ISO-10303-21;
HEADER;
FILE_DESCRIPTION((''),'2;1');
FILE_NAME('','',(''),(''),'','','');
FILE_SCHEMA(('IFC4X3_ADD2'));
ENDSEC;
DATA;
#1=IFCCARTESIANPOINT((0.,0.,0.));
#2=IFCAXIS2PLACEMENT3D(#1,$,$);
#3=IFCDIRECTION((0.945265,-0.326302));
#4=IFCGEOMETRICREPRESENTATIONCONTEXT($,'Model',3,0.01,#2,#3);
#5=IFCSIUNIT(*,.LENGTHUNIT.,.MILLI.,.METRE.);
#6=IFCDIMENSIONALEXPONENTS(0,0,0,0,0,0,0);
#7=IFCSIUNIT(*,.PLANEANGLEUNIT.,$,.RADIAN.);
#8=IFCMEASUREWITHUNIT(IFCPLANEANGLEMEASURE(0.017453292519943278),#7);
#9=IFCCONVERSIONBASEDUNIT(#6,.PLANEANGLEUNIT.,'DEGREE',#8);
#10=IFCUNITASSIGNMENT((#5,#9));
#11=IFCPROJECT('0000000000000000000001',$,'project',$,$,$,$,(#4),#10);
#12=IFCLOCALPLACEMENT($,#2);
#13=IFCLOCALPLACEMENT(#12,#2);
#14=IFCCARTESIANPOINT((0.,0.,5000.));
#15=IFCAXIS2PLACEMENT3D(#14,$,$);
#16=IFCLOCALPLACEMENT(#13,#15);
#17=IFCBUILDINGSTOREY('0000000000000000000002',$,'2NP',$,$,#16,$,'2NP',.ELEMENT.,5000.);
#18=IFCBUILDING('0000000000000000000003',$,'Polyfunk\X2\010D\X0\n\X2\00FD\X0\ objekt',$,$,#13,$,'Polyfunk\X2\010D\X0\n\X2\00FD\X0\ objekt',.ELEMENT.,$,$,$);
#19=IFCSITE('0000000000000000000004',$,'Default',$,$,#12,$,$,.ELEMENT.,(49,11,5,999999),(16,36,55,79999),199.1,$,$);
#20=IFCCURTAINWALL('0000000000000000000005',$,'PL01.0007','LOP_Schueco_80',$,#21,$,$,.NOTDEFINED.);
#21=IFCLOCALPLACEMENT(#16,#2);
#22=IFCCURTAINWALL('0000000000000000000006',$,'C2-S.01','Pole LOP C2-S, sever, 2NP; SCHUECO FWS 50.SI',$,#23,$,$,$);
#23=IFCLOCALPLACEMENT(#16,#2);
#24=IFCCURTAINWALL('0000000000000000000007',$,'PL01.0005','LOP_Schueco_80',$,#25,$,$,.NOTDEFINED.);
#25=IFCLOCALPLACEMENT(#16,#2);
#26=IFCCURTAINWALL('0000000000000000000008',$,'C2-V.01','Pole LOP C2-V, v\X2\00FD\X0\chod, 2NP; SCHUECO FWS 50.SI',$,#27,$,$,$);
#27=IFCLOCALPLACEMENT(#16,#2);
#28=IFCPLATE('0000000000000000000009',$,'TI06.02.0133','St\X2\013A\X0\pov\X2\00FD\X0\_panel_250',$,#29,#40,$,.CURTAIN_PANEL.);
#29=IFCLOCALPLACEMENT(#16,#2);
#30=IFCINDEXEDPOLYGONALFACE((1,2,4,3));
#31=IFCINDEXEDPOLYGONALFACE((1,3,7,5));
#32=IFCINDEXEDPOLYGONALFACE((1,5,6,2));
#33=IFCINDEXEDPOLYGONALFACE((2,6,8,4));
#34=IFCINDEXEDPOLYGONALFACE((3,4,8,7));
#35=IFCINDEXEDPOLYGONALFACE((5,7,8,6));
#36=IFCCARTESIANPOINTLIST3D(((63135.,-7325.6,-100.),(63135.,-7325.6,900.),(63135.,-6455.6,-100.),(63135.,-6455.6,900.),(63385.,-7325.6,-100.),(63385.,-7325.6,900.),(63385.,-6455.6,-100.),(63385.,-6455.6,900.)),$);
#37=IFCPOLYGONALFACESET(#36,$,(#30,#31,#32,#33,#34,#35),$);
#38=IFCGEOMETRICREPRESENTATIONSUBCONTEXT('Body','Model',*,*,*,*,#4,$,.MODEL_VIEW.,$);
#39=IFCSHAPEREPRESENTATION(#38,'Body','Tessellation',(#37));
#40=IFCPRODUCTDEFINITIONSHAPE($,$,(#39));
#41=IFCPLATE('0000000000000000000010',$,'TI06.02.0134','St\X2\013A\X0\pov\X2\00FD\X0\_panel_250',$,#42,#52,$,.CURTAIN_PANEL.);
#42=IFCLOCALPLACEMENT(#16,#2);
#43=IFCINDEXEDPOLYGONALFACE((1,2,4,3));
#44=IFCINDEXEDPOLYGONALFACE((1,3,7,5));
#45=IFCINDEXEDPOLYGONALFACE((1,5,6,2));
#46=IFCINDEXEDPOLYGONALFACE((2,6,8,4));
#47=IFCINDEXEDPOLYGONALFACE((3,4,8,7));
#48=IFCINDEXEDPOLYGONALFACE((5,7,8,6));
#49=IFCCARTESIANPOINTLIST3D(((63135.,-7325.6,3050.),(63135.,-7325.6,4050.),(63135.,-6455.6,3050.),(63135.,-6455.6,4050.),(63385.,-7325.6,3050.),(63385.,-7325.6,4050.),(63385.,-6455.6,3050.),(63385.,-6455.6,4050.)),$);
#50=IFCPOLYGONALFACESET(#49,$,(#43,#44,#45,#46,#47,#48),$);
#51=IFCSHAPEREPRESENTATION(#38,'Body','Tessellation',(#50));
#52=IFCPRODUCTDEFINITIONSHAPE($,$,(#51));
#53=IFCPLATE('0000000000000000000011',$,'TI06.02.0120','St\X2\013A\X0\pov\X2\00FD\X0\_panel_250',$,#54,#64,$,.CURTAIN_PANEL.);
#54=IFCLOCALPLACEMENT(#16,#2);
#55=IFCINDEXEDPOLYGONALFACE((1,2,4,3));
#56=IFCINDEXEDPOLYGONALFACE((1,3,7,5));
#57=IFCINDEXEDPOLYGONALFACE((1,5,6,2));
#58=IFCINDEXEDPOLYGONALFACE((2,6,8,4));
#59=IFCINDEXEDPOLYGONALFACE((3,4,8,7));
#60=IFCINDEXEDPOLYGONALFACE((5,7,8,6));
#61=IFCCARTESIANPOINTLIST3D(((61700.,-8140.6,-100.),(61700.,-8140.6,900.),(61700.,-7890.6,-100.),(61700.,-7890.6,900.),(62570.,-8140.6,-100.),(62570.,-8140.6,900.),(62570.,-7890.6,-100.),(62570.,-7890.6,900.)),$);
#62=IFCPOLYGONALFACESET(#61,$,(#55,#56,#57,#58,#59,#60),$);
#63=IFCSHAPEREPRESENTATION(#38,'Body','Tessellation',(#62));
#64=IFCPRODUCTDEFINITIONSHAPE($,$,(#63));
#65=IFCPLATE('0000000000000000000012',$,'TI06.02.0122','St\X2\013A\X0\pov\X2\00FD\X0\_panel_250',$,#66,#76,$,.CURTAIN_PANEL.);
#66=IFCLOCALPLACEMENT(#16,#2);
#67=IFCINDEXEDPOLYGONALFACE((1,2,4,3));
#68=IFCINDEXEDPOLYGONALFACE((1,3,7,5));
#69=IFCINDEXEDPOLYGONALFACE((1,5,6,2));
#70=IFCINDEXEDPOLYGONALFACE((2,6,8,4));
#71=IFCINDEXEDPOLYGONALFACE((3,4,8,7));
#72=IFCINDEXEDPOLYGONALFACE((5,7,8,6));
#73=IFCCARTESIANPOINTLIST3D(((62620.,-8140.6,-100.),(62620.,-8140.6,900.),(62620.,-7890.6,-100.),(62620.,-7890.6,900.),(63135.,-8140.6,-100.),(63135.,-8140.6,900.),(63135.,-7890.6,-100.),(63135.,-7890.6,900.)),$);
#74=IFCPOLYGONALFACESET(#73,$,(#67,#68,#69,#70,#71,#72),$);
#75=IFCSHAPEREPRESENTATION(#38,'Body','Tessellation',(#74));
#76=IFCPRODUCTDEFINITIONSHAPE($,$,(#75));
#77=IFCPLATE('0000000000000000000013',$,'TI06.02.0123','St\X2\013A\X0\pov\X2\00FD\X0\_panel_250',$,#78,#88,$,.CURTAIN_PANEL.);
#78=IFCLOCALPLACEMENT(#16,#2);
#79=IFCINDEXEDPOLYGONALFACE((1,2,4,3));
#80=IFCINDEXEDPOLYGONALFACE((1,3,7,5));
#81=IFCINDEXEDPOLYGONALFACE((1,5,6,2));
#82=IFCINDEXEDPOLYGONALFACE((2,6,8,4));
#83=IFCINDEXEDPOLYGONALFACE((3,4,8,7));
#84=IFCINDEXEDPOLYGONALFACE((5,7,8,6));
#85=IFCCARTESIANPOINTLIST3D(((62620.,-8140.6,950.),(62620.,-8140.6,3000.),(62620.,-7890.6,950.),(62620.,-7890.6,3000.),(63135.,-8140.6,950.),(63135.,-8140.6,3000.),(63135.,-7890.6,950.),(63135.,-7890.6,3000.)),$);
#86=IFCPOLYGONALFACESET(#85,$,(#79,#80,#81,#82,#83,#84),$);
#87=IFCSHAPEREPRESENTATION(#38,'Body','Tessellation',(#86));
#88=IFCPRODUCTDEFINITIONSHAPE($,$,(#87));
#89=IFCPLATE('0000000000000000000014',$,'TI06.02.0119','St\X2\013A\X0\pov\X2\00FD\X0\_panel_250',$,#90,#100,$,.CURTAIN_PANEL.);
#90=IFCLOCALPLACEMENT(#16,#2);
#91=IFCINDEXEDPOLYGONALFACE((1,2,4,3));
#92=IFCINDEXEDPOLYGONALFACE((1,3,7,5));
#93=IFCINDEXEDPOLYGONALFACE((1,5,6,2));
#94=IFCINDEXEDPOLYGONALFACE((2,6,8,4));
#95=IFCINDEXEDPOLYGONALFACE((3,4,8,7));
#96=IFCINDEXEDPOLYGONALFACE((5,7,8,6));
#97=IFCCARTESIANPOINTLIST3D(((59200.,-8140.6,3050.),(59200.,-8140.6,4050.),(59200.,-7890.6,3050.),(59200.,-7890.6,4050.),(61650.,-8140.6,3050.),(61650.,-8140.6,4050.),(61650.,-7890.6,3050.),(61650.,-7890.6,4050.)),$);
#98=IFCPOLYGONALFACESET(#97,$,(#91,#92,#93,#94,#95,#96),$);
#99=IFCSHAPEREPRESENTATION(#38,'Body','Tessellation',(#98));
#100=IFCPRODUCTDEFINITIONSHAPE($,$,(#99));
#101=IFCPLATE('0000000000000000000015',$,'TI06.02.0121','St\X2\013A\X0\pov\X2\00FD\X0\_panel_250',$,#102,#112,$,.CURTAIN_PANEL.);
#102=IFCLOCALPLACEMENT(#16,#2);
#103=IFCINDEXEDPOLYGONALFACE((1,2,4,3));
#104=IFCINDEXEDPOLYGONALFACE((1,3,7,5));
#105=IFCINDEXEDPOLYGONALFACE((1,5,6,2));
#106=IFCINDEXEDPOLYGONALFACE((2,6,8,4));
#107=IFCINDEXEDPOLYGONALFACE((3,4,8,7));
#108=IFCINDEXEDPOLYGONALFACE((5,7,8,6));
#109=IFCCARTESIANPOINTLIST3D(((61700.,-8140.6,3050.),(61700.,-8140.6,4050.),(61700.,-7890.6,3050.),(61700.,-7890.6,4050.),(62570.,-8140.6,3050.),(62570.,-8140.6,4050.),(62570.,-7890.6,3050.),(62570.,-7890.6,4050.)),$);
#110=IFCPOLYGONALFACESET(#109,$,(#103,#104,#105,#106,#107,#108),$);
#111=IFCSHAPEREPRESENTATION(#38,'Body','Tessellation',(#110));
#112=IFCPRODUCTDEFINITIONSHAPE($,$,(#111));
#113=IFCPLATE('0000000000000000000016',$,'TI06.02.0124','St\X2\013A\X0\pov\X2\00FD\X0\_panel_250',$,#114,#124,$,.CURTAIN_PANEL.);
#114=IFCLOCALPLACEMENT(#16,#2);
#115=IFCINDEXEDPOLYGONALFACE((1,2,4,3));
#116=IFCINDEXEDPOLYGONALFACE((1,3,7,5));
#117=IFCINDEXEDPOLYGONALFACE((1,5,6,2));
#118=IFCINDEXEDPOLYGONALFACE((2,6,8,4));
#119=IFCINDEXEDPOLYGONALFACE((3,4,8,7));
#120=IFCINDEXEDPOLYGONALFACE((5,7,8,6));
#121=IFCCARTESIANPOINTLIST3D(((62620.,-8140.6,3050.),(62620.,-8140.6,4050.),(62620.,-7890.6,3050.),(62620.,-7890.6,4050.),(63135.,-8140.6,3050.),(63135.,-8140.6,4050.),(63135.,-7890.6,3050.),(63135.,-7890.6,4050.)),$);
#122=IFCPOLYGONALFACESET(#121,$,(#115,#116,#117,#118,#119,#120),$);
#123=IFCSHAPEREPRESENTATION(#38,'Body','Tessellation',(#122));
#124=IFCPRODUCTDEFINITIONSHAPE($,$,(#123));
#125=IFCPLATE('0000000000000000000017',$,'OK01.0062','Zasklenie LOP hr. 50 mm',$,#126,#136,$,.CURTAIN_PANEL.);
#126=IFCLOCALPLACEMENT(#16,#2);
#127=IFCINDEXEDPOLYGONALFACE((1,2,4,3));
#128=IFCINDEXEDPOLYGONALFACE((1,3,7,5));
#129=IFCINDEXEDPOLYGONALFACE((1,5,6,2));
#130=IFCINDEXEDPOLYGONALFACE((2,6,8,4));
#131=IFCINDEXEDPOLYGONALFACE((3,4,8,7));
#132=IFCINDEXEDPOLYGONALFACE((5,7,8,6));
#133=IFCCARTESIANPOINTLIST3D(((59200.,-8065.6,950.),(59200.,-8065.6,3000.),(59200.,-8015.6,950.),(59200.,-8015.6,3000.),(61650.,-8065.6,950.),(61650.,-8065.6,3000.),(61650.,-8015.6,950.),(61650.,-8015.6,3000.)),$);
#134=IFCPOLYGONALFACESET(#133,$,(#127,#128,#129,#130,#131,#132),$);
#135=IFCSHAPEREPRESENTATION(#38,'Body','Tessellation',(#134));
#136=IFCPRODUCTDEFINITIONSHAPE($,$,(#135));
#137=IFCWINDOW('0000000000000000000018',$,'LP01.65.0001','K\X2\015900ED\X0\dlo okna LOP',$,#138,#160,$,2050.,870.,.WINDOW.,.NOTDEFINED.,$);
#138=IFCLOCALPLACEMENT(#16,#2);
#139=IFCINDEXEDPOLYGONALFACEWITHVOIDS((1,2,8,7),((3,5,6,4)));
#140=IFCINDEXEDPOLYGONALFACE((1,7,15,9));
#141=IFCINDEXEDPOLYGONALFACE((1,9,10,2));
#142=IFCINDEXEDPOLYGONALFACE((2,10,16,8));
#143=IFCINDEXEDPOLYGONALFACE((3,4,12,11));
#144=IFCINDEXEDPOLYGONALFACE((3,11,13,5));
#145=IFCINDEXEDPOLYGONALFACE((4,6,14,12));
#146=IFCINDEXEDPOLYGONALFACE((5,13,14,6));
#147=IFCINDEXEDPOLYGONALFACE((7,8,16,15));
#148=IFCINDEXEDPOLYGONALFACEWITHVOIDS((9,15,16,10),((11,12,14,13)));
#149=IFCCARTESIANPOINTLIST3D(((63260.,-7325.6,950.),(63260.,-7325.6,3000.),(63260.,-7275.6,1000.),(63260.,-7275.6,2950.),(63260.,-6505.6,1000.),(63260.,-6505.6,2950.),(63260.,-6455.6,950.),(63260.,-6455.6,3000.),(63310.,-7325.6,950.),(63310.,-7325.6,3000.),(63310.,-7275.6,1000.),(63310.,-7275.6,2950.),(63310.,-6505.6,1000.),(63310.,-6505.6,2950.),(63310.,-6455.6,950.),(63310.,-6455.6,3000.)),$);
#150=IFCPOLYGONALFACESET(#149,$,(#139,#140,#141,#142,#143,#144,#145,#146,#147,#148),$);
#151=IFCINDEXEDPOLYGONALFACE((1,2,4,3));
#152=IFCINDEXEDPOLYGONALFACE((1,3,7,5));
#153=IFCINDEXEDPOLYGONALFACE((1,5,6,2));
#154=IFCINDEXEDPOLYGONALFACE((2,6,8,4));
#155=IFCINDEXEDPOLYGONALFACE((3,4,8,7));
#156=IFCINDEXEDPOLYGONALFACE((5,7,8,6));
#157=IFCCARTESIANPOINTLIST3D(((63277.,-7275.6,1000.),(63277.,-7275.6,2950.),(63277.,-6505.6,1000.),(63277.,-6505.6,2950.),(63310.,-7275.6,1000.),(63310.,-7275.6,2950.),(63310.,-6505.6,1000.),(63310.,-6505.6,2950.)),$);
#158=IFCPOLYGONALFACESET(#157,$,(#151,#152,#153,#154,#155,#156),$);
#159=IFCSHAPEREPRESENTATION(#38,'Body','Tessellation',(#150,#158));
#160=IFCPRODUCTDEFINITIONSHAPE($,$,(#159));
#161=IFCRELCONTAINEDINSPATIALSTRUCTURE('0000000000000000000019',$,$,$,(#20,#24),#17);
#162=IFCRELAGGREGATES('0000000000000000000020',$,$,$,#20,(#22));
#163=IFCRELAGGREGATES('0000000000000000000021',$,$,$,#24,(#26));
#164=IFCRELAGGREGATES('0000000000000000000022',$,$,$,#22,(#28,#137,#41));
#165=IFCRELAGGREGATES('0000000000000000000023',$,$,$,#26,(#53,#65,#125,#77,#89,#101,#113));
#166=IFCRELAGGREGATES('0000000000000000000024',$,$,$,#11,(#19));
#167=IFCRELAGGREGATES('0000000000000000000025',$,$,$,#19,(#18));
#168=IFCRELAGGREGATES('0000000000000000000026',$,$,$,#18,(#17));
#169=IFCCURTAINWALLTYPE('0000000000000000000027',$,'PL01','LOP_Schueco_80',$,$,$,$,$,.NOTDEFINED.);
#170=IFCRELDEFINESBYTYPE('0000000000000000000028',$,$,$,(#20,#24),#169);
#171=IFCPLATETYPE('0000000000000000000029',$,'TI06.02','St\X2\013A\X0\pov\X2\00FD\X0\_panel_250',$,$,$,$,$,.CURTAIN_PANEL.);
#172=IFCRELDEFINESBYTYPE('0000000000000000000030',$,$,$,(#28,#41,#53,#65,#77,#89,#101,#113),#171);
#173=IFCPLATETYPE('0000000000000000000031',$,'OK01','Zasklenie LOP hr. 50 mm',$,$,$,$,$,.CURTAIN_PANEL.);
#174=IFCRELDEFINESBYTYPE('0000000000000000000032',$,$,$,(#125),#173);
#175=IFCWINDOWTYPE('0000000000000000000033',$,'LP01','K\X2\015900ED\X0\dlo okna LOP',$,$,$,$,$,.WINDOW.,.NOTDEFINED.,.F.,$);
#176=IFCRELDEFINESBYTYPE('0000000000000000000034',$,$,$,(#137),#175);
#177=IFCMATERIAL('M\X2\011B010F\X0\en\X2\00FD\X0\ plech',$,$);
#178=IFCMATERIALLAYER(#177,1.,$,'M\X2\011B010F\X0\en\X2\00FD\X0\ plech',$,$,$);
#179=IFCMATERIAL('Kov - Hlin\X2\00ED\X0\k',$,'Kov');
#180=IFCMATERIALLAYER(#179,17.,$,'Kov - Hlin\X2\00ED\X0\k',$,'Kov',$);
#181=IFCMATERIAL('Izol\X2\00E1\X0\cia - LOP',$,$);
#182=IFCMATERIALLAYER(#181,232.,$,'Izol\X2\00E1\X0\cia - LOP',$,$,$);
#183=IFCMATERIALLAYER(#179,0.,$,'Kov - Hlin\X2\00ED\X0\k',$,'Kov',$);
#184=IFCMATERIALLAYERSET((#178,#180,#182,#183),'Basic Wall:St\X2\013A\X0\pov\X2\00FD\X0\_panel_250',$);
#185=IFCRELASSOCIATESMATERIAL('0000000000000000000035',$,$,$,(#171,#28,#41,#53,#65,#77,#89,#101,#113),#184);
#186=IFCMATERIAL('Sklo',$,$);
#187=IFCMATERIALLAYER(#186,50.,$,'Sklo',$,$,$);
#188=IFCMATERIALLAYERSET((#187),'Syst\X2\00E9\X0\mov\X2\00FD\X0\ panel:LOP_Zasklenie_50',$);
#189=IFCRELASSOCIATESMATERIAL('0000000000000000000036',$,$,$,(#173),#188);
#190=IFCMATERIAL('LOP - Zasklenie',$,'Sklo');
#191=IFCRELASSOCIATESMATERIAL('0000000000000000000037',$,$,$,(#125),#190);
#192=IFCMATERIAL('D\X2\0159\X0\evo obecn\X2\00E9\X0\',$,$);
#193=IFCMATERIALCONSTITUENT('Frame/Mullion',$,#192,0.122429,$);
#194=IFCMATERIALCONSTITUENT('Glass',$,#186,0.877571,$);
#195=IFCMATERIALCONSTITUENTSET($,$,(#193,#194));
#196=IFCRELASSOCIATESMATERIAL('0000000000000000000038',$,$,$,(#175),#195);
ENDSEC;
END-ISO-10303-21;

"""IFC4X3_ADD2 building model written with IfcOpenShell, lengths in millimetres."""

from ifc_helpers import new_model, entity, si_unit, converted_unit, direction, frame, frame_2d, origin, origin_2d_with_axis, place, context, subcontext, project, spatial, polyline, rectangle, outline, extrude, source, transform, mapped, material, layer, layer_set, layer_usage, constituent, constituent_set, type_object, type_shapes, element, aggregate, save


model = new_model("IFC4X3_ADD2")

# Units and contexts
model_context = context("Model", 3, precision=0.01, world=origin(), true_north=direction((0.945265, -0.326302)))
body_context = subcontext(model_context, "Body", "Model", "MODEL_VIEW")
ifc_project = project(units=[si_unit("LENGTHUNIT", "METRE", prefix="MILLI"), converted_unit("PLANEANGLEUNIT", "DEGREE", entity("IfcPlaneAngleMeasure", 0.017453292519943278), si_unit("PLANEANGLEUNIT", "RADIAN"), dimensions=[0, 0, 0, 0, 0, 0, 0])], contexts=[model_context])

# Site, building, storey
site_placement = place(None, origin())
site = spatial("IfcSite", under=ifc_project, at=site_placement, Name="Default", CompositionType="ELEMENT", RefLatitude=(49, 11, 5, 999999), RefLongitude=(16, 36, 55, 79999), RefElevation=199.1)
building_placement = place(site_placement, origin())
building = spatial("IfcBuilding", under=site, at=building_placement, Name="Polyfunkčný objekt", LongName="Polyfunkčný objekt", CompositionType="ELEMENT")
storey_placement = place(building_placement, frame((0.0, 0.0, 5000.0)))
storey = spatial("IfcBuildingStorey", under=building, at=storey_placement, Name="2NP", LongName="2NP", CompositionType="ELEMENT", Elevation=5000.0)

# Curtain walls
curtain_wall_type = type_object("IfcCurtainWallType", Name="PL01", Description="LOP_Schueco_80", PredefinedType="NOTDEFINED")
curtain_wall_1_placement = place(storey_placement, frame((0.0, 0.0, -5000.0)))
curtain_wall_1 = element("IfcCurtainWall", 1, at=curtain_wall_1_placement, inside=storey, type_object=curtain_wall_type, Name="PL01.0007", Description="LOP_Schueco_80", PredefinedType="NOTDEFINED")
curtain_wall_2 = element("IfcCurtainWall", 2, Name="C2-S.01", Description="Pole LOP C2-S, sever, 2NP; SCHUECO FWS 50.SI")
aggregate(curtain_wall_1, [curtain_wall_2])
curtain_wall_3_placement = place(storey_placement, frame((0.0, 0.0, -5000.0)))
curtain_wall_3 = element("IfcCurtainWall", 3, at=curtain_wall_3_placement, inside=storey, type_object=curtain_wall_type, Name="PL01.0005", Description="LOP_Schueco_80", PredefinedType="NOTDEFINED")
curtain_wall_4 = element("IfcCurtainWall", 4, Name="C2-V.01", Description="Pole LOP C2-V, východ, 2NP; SCHUECO FWS 50.SI")
aggregate(curtain_wall_3, [curtain_wall_4])

# Plates
ifc_material_1 = material(Name="Měďený plech")
ifc_layer_1 = layer(ifc_material_1, 1.0, Name="Měďený plech")
ifc_material_2 = material(Name="Kov - Hliník", Category="Kov")
ifc_layer_2 = layer(ifc_material_2, 17.0, Name="Kov - Hliník", Category="Kov")
ifc_material_3 = material(Name="Izolácia - LOP")
ifc_layer_3 = layer(ifc_material_3, 232.0, Name="Izolácia - LOP")
ifc_layer_4 = layer(ifc_material_2, 0.0, Name="Kov - Hliník", Category="Kov")
ifc_layer_set_1 = layer_set([ifc_layer_1, ifc_layer_2, ifc_layer_3, ifc_layer_4], Name="Basic Wall:Stĺpový_panel_250")
ifc_layer_usage_1 = layer_usage(ifc_layer_set_1, "AXIS2", "NEGATIVE", 125.0)
plate_type_1 = type_object("IfcPlateType", Name="TI06.02", Description="Stĺpový_panel_250", PredefinedType="CURTAIN_PANEL", material=ifc_layer_set_1)
plate_1_placement = place(storey_placement, frame((63260.0, -6455.6, -100.0), z_axis=(0.0, 0.0, 1.0), x_axis=(0.0, -1.0, 0.0)))
plate_1 = element("IfcPlate", 5, at=plate_1_placement, type_object=plate_type_1, material=ifc_layer_usage_1, Name="TI06.02.0133", Description="Stĺpový_panel_250", PredefinedType="CURTAIN_PANEL", context=body_context, shape_type="SweptSolid", body=[
    extrude(rectangle(XDim=250.0, YDim=870.0, at=frame_2d((0.0, 0.0), x_axis=(1.0, 0.0))), frame((435.0, 0.0, 0.0), z_axis=(0.0, 0.0, 1.0), x_axis=(0.0, 1.0, 0.0)), (0.0, 0.0, 1.0), 1000.0),
])
ifc_layer_usage_2 = layer_usage(ifc_layer_set_1, "AXIS2", "NEGATIVE", 125.0)
plate_2_placement = place(storey_placement, frame((63260.0, -6455.6, 3050.0), z_axis=(0.0, 0.0, 1.0), x_axis=(0.0, -1.0, 0.0)))
plate_2 = element("IfcPlate", 6, at=plate_2_placement, type_object=plate_type_1, material=ifc_layer_usage_2, Name="TI06.02.0134", Description="Stĺpový_panel_250", PredefinedType="CURTAIN_PANEL", context=body_context, shape_type="SweptSolid", body=[
    extrude(rectangle(XDim=250.0, YDim=870.0, at=frame_2d((0.0, 0.0), x_axis=(1.0, 0.0))), frame((435.0, 0.0, 0.0), z_axis=(0.0, 0.0, 1.0), x_axis=(0.0, 1.0, 0.0)), (0.0, 0.0, 1.0), 1000.0),
])
ifc_layer_usage_3 = layer_usage(ifc_layer_set_1, "AXIS2", "POSITIVE", -125.0)
plate_3_placement = place(storey_placement, frame((61700.0, -8015.6, -100.0)))
plate_3 = element("IfcPlate", 7, at=plate_3_placement, type_object=plate_type_1, material=ifc_layer_usage_3, Name="TI06.02.0120", Description="Stĺpový_panel_250", PredefinedType="CURTAIN_PANEL", context=body_context, shape_type="SweptSolid", body=[
    extrude(rectangle(XDim=250.0, YDim=870.0, at=frame_2d((0.0, 0.0), x_axis=(1.0, 0.0))), frame((435.0, 0.0, 0.0), z_axis=(0.0, 0.0, 1.0), x_axis=(0.0, 1.0, 0.0)), (0.0, 0.0, 1.0), 1000.0),
])
ifc_layer_usage_4 = layer_usage(ifc_layer_set_1, "AXIS2", "POSITIVE", -125.0)
plate_4_placement = place(storey_placement, frame((62620.0, -8015.6, -100.0)))
plate_4 = element("IfcPlate", 8, at=plate_4_placement, type_object=plate_type_1, material=ifc_layer_usage_4, Name="TI06.02.0122", Description="Stĺpový_panel_250", PredefinedType="CURTAIN_PANEL", context=body_context, shape_type="SweptSolid", body=[
    extrude(rectangle(XDim=250.0, YDim=515.0, at=frame_2d((0.0, 0.0), x_axis=(1.0, 0.0))), frame((257.5, 0.0, 0.0), z_axis=(0.0, 0.0, 1.0), x_axis=(0.0, 1.0, 0.0)), (0.0, 0.0, 1.0), 1000.0),
])
ifc_layer_usage_5 = layer_usage(ifc_layer_set_1, "AXIS2", "POSITIVE", -125.0)
plate_5_placement = place(storey_placement, frame((62620.0, -8015.6, 950.0)))
plate_5 = element("IfcPlate", 9, at=plate_5_placement, type_object=plate_type_1, material=ifc_layer_usage_5, Name="TI06.02.0123", Description="Stĺpový_panel_250", PredefinedType="CURTAIN_PANEL", context=body_context, shape_type="SweptSolid", body=[
    extrude(rectangle(XDim=250.0, YDim=515.0, at=frame_2d((0.0, 0.0), x_axis=(1.0, 0.0))), frame((257.5, 0.0, 0.0), z_axis=(0.0, 0.0, 1.0), x_axis=(0.0, 1.0, 0.0)), (0.0, 0.0, 1.0), 2050.0),
])
ifc_layer_usage_6 = layer_usage(ifc_layer_set_1, "AXIS2", "POSITIVE", -125.0)
plate_6_placement = place(storey_placement, frame((59200.0, -8015.6, 3050.0)))
plate_6 = element("IfcPlate", 10, at=plate_6_placement, type_object=plate_type_1, material=ifc_layer_usage_6, Name="TI06.02.0119", Description="Stĺpový_panel_250", PredefinedType="CURTAIN_PANEL", context=body_context, shape_type="SweptSolid", body=[
    extrude(rectangle(XDim=250.0, YDim=2450.0, at=frame_2d((0.0, 0.0), x_axis=(1.0, 0.0))), frame((1225.0, 0.0, 0.0), z_axis=(0.0, 0.0, 1.0), x_axis=(0.0, 1.0, 0.0)), (0.0, 0.0, 1.0), 1000.0),
])
ifc_layer_usage_7 = layer_usage(ifc_layer_set_1, "AXIS2", "POSITIVE", -125.0)
plate_7_placement = place(storey_placement, frame((61700.0, -8015.6, 3050.0)))
plate_7 = element("IfcPlate", 11, at=plate_7_placement, type_object=plate_type_1, material=ifc_layer_usage_7, Name="TI06.02.0121", Description="Stĺpový_panel_250", PredefinedType="CURTAIN_PANEL", context=body_context, shape_type="SweptSolid", body=[
    extrude(rectangle(XDim=250.0, YDim=870.0, at=frame_2d((0.0, 0.0), x_axis=(1.0, 0.0))), frame((435.0, 0.0, 0.0), z_axis=(0.0, 0.0, 1.0), x_axis=(0.0, 1.0, 0.0)), (0.0, 0.0, 1.0), 1000.0),
])
ifc_layer_usage_8 = layer_usage(ifc_layer_set_1, "AXIS2", "POSITIVE", -125.0)
plate_8_placement = place(storey_placement, frame((62620.0, -8015.6, 3050.0)))
plate_8 = element("IfcPlate", 12, at=plate_8_placement, type_object=plate_type_1, material=ifc_layer_usage_8, Name="TI06.02.0124", Description="Stĺpový_panel_250", PredefinedType="CURTAIN_PANEL", context=body_context, shape_type="SweptSolid", body=[
    extrude(rectangle(XDim=250.0, YDim=515.0, at=frame_2d((0.0, 0.0), x_axis=(1.0, 0.0))), frame((257.5, 0.0, 0.0), z_axis=(0.0, 0.0, 1.0), x_axis=(0.0, 1.0, 0.0)), (0.0, 0.0, 1.0), 1000.0),
])
ifc_material_4 = material(Name="LOP - Zasklenie", Category="Sklo")
ifc_material_5 = material(Name="Sklo")
ifc_layer_5 = layer(ifc_material_5, 50.0, Name="Sklo")
ifc_layer_set_2 = layer_set([ifc_layer_5], Name="Systémový panel:LOP_Zasklenie_50")
plate_type_2 = type_object("IfcPlateType", Name="OK01", Description="Zasklenie LOP hr. 50 mm", PredefinedType="CURTAIN_PANEL", material=ifc_layer_set_2)
shared_shape_1 = source(origin(), body_context, "Body", "SweptSolid", [
    extrude(rectangle(XDim=50.0, YDim=2450.0, at=origin_2d_with_axis()), frame((0.0, -25.0, 0.0), z_axis=(0.0, 0.0, 1.0), x_axis=(0.0, 1.0, 0.0)), (0.0, 0.0, 1.0), 2050.0),
])
type_shapes(plate_type_2, [shared_shape_1])
plate_9_placement = place(curtain_wall_3_placement, frame((60425.0, -8015.6, 5950.0)))
plate_9 = element("IfcPlate", 13, at=plate_9_placement, type_object=plate_type_2, material=ifc_material_4, Name="OK01.0062", Description="Zasklenie LOP hr. 50 mm", PredefinedType="CURTAIN_PANEL", context=body_context, shape_type="MappedRepresentation", body=[
    mapped(shared_shape_1, transform((0.0, 0.0, 0.0), scale=1.0)),
])

# Window
ifc_material_6 = material(Name="Dřevo obecné")
ifc_constituent_1 = constituent(ifc_material_6, Name="Frame/Mullion", fraction=0.122429)
ifc_constituent_2 = constituent(ifc_material_5, Name="Glass", fraction=0.877571)
ifc_constituent_set = constituent_set(constituents=[ifc_constituent_1, ifc_constituent_2])
window_type = type_object("IfcWindowType", Name="LP01", Description="Křídlo okna LOP", ParameterTakesPrecedence=False, PartitioningType="NOTDEFINED", PredefinedType="WINDOW", material=ifc_constituent_set)
shared_shape_2 = source(origin(), body_context, "Body", "SweptSolid", [
    extrude(outline(polyline([(-1025.0, -435.0), (1025.0, -435.0), (1025.0, 435.0), (-1025.0, 435.0), (-1025.0, -435.0)]), holes=[polyline([(-975.0, -385.0), (-975.0, 385.0), (975.0, 385.0), (975.0, -385.0), (-975.0, -385.0)])]), frame((0.0, 0.0, 1025.0), z_axis=(0.0, 1.0, 0.0), x_axis=(0.0, 0.0, -1.0)), (0.0, 0.0, 1.0), 50.0),
    extrude(rectangle(XDim=33.0, YDim=770.0, at=origin_2d_with_axis()), frame((0.0, 33.5, 50.0), z_axis=(0.0, 0.0, 1.0), x_axis=(0.0, -1.0, 0.0)), (0.0, 0.0, 1.0), 1950.0),
])
window_1_placement = place(curtain_wall_1_placement, frame((63260.0, -6890.6, 5950.0), z_axis=(0.0, 0.0, 1.0), x_axis=(0.0, -1.0, 0.0)))
window_1 = element("IfcWindow", 14, at=window_1_placement, type_object=window_type, Name="LP01.65.0001", Description="Křídlo okna LOP", OverallHeight=2050.0, OverallWidth=870.0, PartitioningType="NOTDEFINED", PredefinedType="WINDOW", context=body_context, shape_type="MappedRepresentation", body=[
    mapped(shared_shape_2, transform((0.0, 0.0, 0.0), scale=1.0)),
])
aggregate(curtain_wall_2, [plate_1, window_1, plate_2])
aggregate(curtain_wall_4, [plate_3, plate_4, plate_9, plate_5, plate_6, plate_7, plate_8])

save(model, "model.ifc")
